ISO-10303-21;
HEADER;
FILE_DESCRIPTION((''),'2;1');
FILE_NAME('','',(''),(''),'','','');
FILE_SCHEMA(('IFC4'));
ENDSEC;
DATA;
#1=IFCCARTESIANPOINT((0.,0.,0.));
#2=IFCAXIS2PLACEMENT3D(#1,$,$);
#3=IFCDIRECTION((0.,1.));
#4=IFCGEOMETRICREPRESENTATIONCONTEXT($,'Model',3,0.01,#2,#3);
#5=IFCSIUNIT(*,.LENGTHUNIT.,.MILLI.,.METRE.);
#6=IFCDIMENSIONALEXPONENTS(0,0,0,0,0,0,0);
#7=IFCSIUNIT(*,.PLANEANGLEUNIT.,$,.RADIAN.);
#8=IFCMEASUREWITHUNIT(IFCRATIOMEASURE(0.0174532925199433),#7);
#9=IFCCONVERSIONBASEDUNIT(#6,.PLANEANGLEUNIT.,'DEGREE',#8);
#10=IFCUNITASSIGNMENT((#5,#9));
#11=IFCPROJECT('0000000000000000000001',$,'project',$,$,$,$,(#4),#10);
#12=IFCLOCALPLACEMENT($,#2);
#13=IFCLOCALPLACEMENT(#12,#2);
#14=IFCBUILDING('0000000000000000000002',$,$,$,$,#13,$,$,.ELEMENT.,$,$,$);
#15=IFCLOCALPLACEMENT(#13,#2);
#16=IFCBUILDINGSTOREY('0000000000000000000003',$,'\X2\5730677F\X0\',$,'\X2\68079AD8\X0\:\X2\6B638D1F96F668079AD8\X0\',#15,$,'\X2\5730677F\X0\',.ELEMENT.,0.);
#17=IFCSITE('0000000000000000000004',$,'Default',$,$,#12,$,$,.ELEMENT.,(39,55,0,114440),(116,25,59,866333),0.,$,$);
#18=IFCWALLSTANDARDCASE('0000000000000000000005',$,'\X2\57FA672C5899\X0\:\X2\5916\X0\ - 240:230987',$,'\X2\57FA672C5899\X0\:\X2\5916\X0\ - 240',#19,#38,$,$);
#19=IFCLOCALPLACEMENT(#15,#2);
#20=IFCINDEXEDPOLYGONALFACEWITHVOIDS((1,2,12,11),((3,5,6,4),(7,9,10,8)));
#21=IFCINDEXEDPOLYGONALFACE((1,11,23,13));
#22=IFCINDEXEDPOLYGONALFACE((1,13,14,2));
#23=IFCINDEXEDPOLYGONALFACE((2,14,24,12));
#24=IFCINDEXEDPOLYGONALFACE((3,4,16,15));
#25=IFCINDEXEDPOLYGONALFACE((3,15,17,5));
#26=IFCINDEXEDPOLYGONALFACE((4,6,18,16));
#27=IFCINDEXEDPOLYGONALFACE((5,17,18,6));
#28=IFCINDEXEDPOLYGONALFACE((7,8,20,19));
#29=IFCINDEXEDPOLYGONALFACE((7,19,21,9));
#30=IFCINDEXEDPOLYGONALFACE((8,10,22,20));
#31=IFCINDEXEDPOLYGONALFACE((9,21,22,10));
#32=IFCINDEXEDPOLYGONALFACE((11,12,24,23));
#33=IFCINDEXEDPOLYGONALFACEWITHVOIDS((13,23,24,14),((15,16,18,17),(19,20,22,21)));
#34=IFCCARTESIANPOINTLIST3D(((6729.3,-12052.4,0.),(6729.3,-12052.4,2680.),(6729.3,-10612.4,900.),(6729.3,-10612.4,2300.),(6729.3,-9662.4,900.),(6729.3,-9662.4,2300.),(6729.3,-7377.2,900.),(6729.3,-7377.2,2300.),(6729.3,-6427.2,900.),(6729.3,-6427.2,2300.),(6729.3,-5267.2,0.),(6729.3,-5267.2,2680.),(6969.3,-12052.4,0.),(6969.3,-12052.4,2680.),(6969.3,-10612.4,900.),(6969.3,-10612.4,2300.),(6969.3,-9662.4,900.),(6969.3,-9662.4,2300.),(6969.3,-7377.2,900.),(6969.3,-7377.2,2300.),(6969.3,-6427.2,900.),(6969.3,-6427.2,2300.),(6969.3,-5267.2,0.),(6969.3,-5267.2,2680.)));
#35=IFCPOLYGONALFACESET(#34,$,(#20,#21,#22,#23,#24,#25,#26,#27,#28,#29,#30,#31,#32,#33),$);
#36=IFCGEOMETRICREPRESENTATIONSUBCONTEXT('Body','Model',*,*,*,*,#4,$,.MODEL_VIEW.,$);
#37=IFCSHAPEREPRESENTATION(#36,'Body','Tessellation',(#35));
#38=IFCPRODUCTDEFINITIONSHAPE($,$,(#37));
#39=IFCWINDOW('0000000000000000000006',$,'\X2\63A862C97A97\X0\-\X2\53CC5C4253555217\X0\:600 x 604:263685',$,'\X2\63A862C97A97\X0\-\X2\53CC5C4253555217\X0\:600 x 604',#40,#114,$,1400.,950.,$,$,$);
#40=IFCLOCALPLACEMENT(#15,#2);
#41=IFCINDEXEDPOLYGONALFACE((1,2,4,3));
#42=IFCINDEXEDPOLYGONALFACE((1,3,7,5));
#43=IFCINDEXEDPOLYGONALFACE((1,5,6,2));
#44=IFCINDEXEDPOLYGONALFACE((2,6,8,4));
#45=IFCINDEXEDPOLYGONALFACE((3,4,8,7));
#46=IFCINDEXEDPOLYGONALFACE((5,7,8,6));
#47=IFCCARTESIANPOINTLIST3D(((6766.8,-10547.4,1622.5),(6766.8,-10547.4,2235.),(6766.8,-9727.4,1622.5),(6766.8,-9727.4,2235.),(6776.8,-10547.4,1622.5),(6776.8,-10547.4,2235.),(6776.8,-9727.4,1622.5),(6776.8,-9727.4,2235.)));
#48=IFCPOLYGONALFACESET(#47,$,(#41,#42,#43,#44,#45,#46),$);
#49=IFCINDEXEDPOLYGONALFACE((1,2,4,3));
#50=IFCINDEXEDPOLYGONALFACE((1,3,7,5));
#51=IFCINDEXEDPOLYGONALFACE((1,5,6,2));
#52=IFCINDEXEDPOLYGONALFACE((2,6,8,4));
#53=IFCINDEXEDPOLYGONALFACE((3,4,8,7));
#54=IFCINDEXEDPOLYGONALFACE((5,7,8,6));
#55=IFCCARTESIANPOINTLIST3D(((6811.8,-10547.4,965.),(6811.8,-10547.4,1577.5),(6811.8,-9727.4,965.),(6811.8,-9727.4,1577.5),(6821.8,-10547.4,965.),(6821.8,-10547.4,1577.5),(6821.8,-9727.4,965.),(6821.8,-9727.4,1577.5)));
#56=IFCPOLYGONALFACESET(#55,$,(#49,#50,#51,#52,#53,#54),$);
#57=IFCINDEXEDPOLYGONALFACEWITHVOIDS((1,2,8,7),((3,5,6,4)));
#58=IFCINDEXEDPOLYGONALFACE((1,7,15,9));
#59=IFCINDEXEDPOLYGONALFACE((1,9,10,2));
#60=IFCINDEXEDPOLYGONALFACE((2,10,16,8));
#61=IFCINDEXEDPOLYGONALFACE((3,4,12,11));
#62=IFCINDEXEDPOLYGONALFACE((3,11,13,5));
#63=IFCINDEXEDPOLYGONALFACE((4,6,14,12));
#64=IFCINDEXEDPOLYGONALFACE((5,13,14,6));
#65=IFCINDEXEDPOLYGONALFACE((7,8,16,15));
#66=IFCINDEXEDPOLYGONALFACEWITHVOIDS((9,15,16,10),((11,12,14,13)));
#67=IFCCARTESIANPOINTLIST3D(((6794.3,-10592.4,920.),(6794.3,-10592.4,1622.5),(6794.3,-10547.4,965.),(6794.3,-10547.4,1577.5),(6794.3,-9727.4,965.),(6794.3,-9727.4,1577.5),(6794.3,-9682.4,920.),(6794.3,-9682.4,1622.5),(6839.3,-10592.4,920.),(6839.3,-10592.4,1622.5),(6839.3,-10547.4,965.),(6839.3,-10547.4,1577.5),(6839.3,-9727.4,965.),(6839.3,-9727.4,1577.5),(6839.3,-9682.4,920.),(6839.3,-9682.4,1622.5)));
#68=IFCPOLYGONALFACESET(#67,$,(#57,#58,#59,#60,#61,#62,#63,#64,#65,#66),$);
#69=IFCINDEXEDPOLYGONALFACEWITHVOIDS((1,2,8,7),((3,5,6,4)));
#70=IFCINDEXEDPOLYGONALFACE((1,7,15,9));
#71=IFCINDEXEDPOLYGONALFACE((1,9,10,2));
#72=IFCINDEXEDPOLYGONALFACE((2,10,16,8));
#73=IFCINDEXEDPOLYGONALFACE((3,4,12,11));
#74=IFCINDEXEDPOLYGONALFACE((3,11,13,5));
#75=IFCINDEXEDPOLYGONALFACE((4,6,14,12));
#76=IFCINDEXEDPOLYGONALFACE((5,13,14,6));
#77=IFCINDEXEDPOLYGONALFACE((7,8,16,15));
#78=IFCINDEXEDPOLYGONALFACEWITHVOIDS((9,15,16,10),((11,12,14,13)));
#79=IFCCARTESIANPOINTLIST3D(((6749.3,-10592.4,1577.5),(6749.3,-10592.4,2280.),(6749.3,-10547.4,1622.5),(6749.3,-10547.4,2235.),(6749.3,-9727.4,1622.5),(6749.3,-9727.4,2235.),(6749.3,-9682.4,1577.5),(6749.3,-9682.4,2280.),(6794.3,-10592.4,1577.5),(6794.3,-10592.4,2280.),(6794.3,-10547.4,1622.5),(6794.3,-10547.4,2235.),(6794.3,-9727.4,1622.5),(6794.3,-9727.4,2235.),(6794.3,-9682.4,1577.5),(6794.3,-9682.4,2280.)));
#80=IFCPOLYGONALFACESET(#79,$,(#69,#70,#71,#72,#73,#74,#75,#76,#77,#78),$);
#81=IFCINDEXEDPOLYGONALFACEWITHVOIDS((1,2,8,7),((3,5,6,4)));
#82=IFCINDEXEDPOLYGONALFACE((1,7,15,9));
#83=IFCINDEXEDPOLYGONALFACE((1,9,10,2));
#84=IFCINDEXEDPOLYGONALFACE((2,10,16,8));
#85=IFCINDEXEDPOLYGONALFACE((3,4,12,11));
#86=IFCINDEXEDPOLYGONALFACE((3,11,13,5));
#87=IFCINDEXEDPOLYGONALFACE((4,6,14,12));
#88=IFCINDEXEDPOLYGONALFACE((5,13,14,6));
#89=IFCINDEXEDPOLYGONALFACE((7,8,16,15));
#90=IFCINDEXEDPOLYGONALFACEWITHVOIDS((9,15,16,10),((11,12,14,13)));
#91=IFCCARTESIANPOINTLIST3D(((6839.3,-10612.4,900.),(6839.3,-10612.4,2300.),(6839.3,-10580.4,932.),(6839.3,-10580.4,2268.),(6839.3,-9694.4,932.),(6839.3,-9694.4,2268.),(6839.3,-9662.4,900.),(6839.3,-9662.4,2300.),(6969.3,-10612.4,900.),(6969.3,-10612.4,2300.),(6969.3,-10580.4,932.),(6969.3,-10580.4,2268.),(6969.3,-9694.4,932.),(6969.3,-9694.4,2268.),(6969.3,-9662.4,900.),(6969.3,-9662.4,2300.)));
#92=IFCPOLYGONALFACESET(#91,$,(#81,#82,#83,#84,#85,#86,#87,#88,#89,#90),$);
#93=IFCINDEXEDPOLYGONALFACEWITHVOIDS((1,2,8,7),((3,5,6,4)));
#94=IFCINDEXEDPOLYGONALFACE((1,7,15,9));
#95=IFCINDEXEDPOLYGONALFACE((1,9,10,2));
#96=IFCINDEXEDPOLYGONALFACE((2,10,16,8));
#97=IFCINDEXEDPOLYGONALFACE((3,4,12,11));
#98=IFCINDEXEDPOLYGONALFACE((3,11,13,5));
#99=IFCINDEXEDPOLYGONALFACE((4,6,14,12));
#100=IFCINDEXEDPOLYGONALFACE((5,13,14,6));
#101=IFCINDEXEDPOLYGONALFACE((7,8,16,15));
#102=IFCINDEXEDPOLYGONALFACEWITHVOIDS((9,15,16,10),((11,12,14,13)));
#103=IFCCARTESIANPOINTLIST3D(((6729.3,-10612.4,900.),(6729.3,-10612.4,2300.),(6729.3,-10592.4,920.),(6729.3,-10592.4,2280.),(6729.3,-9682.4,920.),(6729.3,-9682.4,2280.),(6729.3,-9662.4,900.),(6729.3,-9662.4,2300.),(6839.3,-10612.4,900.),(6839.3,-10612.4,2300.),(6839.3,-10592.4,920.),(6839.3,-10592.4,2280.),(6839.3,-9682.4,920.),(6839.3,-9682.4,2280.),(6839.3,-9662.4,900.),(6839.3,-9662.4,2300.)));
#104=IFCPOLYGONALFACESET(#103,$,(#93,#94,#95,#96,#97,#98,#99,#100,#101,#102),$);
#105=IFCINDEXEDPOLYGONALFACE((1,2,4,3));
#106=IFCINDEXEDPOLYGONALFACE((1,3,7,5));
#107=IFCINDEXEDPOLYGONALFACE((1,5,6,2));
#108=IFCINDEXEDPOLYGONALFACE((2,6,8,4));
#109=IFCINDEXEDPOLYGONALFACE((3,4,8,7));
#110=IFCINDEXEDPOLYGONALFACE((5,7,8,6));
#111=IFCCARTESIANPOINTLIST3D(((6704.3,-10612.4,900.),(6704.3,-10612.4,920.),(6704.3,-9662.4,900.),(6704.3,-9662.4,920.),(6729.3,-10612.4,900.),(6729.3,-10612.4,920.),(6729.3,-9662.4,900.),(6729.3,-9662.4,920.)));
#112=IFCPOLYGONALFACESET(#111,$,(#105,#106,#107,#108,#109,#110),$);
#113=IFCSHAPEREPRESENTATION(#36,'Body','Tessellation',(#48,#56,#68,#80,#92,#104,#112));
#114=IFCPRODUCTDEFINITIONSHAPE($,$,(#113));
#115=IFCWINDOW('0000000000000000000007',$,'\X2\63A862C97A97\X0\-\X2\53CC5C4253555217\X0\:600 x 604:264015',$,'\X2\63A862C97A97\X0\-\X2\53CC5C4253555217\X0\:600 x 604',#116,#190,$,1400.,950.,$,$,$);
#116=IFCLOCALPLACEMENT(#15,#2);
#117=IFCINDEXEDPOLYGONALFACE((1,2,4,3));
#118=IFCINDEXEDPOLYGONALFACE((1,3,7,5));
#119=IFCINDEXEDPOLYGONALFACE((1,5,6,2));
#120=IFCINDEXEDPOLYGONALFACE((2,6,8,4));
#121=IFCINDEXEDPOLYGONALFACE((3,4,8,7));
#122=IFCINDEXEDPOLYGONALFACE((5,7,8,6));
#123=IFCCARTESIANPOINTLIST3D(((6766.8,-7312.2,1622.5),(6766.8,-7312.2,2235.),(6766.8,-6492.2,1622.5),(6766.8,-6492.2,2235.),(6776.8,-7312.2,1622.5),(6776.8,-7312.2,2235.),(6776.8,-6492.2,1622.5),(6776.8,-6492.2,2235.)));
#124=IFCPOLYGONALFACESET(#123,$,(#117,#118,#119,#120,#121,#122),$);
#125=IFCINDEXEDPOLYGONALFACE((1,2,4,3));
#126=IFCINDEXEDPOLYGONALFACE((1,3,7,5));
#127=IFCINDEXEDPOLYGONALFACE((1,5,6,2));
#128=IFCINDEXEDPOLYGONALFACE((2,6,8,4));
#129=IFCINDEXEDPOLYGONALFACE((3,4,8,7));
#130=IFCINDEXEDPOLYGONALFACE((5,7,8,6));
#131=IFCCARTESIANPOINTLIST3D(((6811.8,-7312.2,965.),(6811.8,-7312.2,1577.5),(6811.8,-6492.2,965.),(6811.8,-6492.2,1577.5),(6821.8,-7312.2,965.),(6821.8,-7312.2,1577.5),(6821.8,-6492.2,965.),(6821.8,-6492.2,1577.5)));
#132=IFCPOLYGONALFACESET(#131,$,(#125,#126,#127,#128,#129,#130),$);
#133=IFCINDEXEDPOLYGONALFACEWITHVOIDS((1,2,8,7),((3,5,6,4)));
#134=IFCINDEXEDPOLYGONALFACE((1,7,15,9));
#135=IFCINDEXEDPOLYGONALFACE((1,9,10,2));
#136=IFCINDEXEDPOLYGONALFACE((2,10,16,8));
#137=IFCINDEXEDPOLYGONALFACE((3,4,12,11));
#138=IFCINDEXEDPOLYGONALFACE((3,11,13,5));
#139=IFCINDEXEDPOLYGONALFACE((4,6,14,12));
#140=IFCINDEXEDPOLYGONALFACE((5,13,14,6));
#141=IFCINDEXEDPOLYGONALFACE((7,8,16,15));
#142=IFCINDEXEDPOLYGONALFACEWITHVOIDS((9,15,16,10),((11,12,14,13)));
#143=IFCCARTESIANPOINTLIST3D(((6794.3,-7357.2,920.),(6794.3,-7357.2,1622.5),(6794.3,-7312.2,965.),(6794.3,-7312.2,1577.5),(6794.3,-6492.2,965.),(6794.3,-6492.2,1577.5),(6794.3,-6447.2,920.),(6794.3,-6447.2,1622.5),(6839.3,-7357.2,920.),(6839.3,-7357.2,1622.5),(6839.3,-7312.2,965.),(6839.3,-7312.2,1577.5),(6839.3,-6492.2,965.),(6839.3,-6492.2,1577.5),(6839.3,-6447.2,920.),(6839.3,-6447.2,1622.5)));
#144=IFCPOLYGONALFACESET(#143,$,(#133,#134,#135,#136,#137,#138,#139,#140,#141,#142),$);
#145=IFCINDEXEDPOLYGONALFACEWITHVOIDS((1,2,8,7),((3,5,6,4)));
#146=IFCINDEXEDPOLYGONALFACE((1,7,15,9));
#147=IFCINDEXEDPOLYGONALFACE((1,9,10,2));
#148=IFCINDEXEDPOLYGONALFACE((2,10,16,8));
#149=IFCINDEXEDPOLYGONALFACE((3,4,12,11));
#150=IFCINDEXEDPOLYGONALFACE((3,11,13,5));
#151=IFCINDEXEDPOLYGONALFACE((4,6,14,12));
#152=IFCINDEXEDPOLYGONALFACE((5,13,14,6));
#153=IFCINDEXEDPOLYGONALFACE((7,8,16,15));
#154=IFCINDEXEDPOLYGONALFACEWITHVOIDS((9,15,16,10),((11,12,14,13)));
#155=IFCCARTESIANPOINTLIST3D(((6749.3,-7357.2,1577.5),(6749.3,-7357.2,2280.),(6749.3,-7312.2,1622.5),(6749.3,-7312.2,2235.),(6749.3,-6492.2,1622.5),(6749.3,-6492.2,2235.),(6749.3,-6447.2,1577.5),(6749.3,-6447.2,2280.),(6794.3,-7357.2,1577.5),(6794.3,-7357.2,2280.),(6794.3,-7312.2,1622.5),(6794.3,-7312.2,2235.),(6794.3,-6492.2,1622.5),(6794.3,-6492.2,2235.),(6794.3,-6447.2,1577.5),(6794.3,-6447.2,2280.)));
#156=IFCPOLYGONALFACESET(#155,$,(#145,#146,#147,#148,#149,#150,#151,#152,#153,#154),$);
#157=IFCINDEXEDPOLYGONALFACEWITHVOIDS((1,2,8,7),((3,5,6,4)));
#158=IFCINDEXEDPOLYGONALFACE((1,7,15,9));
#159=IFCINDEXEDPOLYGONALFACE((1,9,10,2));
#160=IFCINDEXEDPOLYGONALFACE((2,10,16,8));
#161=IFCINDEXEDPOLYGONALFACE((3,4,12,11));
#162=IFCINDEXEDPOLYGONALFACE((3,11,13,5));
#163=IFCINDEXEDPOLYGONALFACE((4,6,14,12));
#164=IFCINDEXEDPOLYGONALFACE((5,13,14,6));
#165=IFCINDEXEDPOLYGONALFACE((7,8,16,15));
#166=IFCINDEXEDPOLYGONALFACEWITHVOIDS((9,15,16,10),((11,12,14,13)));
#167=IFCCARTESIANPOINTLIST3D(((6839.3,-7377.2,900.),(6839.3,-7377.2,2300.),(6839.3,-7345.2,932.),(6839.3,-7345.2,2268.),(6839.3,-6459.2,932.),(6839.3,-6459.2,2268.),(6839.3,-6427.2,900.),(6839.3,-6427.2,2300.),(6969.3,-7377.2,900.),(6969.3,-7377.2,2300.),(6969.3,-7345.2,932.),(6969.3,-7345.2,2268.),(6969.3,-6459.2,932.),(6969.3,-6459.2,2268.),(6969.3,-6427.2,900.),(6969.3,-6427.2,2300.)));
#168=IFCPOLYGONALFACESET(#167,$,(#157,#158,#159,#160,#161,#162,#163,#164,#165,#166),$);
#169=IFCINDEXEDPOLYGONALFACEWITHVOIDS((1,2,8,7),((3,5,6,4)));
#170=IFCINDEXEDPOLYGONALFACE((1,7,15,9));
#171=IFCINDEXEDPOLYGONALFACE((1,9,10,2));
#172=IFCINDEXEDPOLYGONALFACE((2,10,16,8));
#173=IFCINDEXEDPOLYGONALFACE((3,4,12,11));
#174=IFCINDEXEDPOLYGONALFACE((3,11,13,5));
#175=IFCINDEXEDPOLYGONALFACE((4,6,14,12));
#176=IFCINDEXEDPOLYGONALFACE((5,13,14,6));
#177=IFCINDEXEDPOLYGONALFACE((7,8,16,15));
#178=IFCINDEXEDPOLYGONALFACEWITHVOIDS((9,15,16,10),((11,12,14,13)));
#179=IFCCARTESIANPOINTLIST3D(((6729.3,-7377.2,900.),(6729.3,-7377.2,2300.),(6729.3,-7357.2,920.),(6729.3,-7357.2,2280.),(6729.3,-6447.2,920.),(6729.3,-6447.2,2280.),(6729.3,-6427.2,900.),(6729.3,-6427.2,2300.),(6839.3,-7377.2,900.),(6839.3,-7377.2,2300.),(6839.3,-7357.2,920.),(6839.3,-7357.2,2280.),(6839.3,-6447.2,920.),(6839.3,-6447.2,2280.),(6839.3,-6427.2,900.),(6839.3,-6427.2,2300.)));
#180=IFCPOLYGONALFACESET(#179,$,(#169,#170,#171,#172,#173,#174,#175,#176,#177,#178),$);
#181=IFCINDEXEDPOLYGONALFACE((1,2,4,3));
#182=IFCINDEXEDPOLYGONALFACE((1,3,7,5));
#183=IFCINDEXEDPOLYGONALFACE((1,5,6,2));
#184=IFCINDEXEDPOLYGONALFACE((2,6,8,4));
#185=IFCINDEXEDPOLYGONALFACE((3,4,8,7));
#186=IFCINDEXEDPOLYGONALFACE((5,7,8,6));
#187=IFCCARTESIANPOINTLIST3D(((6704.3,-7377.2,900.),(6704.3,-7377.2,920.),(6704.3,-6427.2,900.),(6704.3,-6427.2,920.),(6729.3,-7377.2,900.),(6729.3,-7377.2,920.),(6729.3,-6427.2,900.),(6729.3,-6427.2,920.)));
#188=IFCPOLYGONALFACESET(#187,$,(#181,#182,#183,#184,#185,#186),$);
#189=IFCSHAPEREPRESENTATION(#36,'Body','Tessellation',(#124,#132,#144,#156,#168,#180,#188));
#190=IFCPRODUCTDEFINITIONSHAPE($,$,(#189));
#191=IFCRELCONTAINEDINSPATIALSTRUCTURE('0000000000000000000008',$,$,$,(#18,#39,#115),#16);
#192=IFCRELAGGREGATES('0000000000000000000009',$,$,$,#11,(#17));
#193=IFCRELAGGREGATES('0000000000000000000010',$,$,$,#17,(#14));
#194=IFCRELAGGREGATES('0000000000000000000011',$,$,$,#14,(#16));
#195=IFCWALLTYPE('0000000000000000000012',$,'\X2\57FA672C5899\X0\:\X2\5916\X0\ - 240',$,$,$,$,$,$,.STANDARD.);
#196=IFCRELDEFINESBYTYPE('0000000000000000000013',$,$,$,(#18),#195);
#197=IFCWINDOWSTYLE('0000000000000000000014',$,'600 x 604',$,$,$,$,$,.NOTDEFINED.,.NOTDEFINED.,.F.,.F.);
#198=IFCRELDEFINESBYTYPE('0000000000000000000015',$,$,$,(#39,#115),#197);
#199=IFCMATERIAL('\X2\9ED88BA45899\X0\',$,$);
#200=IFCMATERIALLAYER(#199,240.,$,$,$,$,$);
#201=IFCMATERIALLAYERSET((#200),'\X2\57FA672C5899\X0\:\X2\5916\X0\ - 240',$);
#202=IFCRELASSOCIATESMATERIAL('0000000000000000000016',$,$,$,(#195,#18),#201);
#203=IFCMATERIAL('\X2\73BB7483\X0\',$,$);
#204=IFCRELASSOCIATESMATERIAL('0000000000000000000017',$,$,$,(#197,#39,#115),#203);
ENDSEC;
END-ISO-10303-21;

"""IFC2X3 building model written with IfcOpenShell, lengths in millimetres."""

from ifc_helpers import new_model, entity, si_unit, converted_unit, direction, frame, frame_2d, origin, origin_2d_with_axis, place, context, subcontext, project, spatial, polyline, rectangle, outline, extrude, source, transform, mapped, material, layer, layer_set, layer_usage, type_object, type_shapes, element, fill, save


model = new_model("IFC2X3")

# Units and contexts
model_context = context("Model", 3, precision=0.01, world=origin(), true_north=direction((0.0, 1.0)))
body_context = subcontext(model_context, "Body", "Model", "MODEL_VIEW")
ifc_project = project(units=[si_unit("LENGTHUNIT", "METRE", prefix="MILLI"), converted_unit("PLANEANGLEUNIT", "DEGREE", entity("IfcRatioMeasure", 0.0174532925199433), si_unit("PLANEANGLEUNIT", "RADIAN"), dimensions=[0, 0, 0, 0, 0, 0, 0])], contexts=[model_context])

# Site, building, storey
site_placement = place(None, origin())
site = spatial("IfcSite", under=ifc_project, at=site_placement, Name="Default", CompositionType="ELEMENT", RefLatitude=(39, 55, 0, 114440), RefLongitude=(116, 25, 59, 866333), RefElevation=0.0)
building_placement = place(site_placement, origin())
building = spatial("IfcBuilding", under=site, at=building_placement, CompositionType="ELEMENT")
storey_placement = place(building_placement, origin())
storey = spatial("IfcBuildingStorey", under=building, at=storey_placement, Name="地板", ObjectType="标高:正负零标高", LongName="地板", CompositionType="ELEMENT", Elevation=0.0)

# Shared definitions
ifc_material_1 = material(Name="默认墙")

# Shared definitions
ifc_layer_1 = layer(ifc_material_1, 240.0)
ifc_layer_set_1 = layer_set([ifc_layer_1], Name="基本墙:外 - 240")
wall_type_1 = type_object("IfcWallType", Name="基本墙:外 - 240", PredefinedType="STANDARD", material=ifc_layer_set_1)

# Wall, openings, windows
ifc_layer_usage_1 = layer_usage(ifc_layer_set_1, "AXIS2", "NEGATIVE", 120.0)
wall_1_placement = place(storey_placement, frame((6849.3, -12052.4, 0.0), z_axis=(0.0, 0.0, 1.0), x_axis=(0.0, 1.0, 0.0)))
wall_1 = element("IfcWallStandardCase", 1, at=wall_1_placement, inside=storey, type_object=wall_type_1, material=ifc_layer_usage_1, Name="基本墙:外 - 240:230987", ObjectType="基本墙:外 - 240", context=body_context, shape_type="SweptSolid", body=[
    extrude(rectangle(XDim=6785.2, YDim=240.0, at=frame_2d((3392.6, 0.0), x_axis=(-1.0, 0.0))), origin(), (0.0, 0.0, 1.0), 2680.0),
])
opening_1_placement = place(wall_1_placement, frame((1440.0, -120.0, 900.0)))
opening_1 = element("IfcOpeningElement", 2, at=opening_1_placement, cuts=wall_1, ObjectType="Opening", context=body_context, shape_type="SweptSolid", body=[
    extrude(rectangle(XDim=1400.0, YDim=950.0, at=frame_2d((700.0, 475.0), x_axis=(-1.0, 0.0))), frame((0.0, 0.0, 0.0), z_axis=(0.0, 1.0, 0.0), x_axis=(0.0, 0.0, 1.0)), (0.0, 0.0, 1.0), 240.0),
])
opening_2_placement = place(wall_1_placement, frame((4675.2, -120.0, 900.0)))
opening_2 = element("IfcOpeningElement", 3, at=opening_2_placement, cuts=wall_1, ObjectType="Opening", context=body_context, shape_type="SweptSolid", body=[
    extrude(rectangle(XDim=1400.0, YDim=950.0, at=frame_2d((700.0, 475.0), x_axis=(-1.0, 0.0))), frame((0.0, 0.0, 0.0), z_axis=(0.0, 1.0, 0.0), x_axis=(0.0, 0.0, 1.0)), (0.0, 0.0, 1.0), 240.0),
])
ifc_material_2 = material(Name="玻璃")
window_style_1 = type_object("IfcWindowStyle", Name="600 x 604", ConstructionType="NOTDEFINED", OperationType="NOTDEFINED", ParameterTakesPrecedence=False, Sizeable=False, material=ifc_material_2)
shared_shape_1 = source(origin(), body_context, "Body", "SweptSolid", [
    extrude(rectangle(XDim=10.0, YDim=820.0, at=origin_2d_with_axis()), frame((475.0, 197.5, 722.5), z_axis=(0.0, 0.0, 1.0), x_axis=(0.0, -1.0, 0.0)), (0.0, 0.0, 1.0), 612.5),
    extrude(rectangle(XDim=10.0, YDim=820.0, at=origin_2d_with_axis()), frame((475.0, 152.5, 65.0), z_axis=(0.0, 0.0, 1.0), x_axis=(0.0, -1.0, 0.0)), (0.0, 0.0, 1.0), 612.5),
    extrude(outline(polyline([(-455.0, -351.2), (455.0, -351.2), (455.0, 351.2), (-455.0, 351.2), (-455.0, -351.2)]), holes=[polyline([(-410.0, -306.2), (-410.0, 306.2), (410.0, 306.2), (410.0, -306.2), (-410.0, -306.2)])]), frame((475.0, 130.0, 371.3), z_axis=(0.0, 1.0, 0.0), x_axis=(1.0, 0.0, 0.0)), (0.0, 0.0, 1.0), 45.0),
    extrude(outline(polyline([(-455.0, -351.2), (455.0, -351.2), (455.0, 351.2), (-455.0, 351.2), (-455.0, -351.2)]), holes=[polyline([(-410.0, -306.2), (-410.0, 306.2), (410.0, 306.2), (410.0, -306.2), (-410.0, -306.2)])]), frame((475.0, 175.0, 1028.8), z_axis=(0.0, 1.0, 0.0), x_axis=(1.0, 0.0, 0.0)), (0.0, 0.0, 1.0), 45.0),
    extrude(outline(polyline([(-475.0, -700.0), (475.0, -700.0), (475.0, 700.0), (-475.0, 700.0), (-475.0, -700.0)]), holes=[polyline([(-443.0, -668.0), (-443.0, 668.0), (443.0, 668.0), (443.0, -668.0), (-443.0, -668.0)])]), frame((475.0, 0.0, 700.0), z_axis=(0.0, 1.0, 0.0), x_axis=(1.0, 0.0, 0.0)), (0.0, 0.0, 1.0), 130.0),
    extrude(outline(polyline([(-700.0, -475.0), (700.0, -475.0), (700.0, 475.0), (-700.0, 475.0), (-700.0, -475.0)]), holes=[polyline([(-680.0, -455.0), (-680.0, 455.0), (680.0, 455.0), (680.0, -455.0), (-680.0, -455.0)])]), frame((475.0, 130.0, 700.0), z_axis=(0.0, 1.0, 0.0), x_axis=(0.0, 0.0, -1.0)), (0.0, 0.0, 1.0), 110.0),
    extrude(rectangle(XDim=25.0, YDim=950.0, at=origin_2d_with_axis()), frame((475.0, 252.5, 0.0), z_axis=(0.0, 0.0, 1.0), x_axis=(0.0, -1.0, 0.0)), (0.0, 0.0, 1.0), 20.0),
])
type_shapes(window_style_1, [shared_shape_1])
window_1_placement = place(opening_1_placement, origin())
window_1 = element("IfcWindow", 4, at=window_1_placement, inside=storey, type_object=window_style_1, material=ifc_material_2, Name="推拉窗-双层单列:600 x 604:263685", ObjectType="推拉窗-双层单列:600 x 604", OverallHeight=1400.0, OverallWidth=950.0, context=body_context, shape_type="MappedRepresentation", body=[
    mapped(shared_shape_1, transform((0.0, 0.0, 0.0), scale=1.0)),
])
fill(opening_1, window_1)
window_2_placement = place(opening_2_placement, origin())
window_2 = element("IfcWindow", 5, at=window_2_placement, inside=storey, type_object=window_style_1, material=ifc_material_2, Name="推拉窗-双层单列:600 x 604:264015", ObjectType="推拉窗-双层单列:600 x 604", OverallHeight=1400.0, OverallWidth=950.0, context=body_context, shape_type="MappedRepresentation", body=[
    mapped(shared_shape_1, transform((0.0, 0.0, 0.0), scale=1.0)),
])
fill(opening_2, window_2)

save(model, "model.ifc")
